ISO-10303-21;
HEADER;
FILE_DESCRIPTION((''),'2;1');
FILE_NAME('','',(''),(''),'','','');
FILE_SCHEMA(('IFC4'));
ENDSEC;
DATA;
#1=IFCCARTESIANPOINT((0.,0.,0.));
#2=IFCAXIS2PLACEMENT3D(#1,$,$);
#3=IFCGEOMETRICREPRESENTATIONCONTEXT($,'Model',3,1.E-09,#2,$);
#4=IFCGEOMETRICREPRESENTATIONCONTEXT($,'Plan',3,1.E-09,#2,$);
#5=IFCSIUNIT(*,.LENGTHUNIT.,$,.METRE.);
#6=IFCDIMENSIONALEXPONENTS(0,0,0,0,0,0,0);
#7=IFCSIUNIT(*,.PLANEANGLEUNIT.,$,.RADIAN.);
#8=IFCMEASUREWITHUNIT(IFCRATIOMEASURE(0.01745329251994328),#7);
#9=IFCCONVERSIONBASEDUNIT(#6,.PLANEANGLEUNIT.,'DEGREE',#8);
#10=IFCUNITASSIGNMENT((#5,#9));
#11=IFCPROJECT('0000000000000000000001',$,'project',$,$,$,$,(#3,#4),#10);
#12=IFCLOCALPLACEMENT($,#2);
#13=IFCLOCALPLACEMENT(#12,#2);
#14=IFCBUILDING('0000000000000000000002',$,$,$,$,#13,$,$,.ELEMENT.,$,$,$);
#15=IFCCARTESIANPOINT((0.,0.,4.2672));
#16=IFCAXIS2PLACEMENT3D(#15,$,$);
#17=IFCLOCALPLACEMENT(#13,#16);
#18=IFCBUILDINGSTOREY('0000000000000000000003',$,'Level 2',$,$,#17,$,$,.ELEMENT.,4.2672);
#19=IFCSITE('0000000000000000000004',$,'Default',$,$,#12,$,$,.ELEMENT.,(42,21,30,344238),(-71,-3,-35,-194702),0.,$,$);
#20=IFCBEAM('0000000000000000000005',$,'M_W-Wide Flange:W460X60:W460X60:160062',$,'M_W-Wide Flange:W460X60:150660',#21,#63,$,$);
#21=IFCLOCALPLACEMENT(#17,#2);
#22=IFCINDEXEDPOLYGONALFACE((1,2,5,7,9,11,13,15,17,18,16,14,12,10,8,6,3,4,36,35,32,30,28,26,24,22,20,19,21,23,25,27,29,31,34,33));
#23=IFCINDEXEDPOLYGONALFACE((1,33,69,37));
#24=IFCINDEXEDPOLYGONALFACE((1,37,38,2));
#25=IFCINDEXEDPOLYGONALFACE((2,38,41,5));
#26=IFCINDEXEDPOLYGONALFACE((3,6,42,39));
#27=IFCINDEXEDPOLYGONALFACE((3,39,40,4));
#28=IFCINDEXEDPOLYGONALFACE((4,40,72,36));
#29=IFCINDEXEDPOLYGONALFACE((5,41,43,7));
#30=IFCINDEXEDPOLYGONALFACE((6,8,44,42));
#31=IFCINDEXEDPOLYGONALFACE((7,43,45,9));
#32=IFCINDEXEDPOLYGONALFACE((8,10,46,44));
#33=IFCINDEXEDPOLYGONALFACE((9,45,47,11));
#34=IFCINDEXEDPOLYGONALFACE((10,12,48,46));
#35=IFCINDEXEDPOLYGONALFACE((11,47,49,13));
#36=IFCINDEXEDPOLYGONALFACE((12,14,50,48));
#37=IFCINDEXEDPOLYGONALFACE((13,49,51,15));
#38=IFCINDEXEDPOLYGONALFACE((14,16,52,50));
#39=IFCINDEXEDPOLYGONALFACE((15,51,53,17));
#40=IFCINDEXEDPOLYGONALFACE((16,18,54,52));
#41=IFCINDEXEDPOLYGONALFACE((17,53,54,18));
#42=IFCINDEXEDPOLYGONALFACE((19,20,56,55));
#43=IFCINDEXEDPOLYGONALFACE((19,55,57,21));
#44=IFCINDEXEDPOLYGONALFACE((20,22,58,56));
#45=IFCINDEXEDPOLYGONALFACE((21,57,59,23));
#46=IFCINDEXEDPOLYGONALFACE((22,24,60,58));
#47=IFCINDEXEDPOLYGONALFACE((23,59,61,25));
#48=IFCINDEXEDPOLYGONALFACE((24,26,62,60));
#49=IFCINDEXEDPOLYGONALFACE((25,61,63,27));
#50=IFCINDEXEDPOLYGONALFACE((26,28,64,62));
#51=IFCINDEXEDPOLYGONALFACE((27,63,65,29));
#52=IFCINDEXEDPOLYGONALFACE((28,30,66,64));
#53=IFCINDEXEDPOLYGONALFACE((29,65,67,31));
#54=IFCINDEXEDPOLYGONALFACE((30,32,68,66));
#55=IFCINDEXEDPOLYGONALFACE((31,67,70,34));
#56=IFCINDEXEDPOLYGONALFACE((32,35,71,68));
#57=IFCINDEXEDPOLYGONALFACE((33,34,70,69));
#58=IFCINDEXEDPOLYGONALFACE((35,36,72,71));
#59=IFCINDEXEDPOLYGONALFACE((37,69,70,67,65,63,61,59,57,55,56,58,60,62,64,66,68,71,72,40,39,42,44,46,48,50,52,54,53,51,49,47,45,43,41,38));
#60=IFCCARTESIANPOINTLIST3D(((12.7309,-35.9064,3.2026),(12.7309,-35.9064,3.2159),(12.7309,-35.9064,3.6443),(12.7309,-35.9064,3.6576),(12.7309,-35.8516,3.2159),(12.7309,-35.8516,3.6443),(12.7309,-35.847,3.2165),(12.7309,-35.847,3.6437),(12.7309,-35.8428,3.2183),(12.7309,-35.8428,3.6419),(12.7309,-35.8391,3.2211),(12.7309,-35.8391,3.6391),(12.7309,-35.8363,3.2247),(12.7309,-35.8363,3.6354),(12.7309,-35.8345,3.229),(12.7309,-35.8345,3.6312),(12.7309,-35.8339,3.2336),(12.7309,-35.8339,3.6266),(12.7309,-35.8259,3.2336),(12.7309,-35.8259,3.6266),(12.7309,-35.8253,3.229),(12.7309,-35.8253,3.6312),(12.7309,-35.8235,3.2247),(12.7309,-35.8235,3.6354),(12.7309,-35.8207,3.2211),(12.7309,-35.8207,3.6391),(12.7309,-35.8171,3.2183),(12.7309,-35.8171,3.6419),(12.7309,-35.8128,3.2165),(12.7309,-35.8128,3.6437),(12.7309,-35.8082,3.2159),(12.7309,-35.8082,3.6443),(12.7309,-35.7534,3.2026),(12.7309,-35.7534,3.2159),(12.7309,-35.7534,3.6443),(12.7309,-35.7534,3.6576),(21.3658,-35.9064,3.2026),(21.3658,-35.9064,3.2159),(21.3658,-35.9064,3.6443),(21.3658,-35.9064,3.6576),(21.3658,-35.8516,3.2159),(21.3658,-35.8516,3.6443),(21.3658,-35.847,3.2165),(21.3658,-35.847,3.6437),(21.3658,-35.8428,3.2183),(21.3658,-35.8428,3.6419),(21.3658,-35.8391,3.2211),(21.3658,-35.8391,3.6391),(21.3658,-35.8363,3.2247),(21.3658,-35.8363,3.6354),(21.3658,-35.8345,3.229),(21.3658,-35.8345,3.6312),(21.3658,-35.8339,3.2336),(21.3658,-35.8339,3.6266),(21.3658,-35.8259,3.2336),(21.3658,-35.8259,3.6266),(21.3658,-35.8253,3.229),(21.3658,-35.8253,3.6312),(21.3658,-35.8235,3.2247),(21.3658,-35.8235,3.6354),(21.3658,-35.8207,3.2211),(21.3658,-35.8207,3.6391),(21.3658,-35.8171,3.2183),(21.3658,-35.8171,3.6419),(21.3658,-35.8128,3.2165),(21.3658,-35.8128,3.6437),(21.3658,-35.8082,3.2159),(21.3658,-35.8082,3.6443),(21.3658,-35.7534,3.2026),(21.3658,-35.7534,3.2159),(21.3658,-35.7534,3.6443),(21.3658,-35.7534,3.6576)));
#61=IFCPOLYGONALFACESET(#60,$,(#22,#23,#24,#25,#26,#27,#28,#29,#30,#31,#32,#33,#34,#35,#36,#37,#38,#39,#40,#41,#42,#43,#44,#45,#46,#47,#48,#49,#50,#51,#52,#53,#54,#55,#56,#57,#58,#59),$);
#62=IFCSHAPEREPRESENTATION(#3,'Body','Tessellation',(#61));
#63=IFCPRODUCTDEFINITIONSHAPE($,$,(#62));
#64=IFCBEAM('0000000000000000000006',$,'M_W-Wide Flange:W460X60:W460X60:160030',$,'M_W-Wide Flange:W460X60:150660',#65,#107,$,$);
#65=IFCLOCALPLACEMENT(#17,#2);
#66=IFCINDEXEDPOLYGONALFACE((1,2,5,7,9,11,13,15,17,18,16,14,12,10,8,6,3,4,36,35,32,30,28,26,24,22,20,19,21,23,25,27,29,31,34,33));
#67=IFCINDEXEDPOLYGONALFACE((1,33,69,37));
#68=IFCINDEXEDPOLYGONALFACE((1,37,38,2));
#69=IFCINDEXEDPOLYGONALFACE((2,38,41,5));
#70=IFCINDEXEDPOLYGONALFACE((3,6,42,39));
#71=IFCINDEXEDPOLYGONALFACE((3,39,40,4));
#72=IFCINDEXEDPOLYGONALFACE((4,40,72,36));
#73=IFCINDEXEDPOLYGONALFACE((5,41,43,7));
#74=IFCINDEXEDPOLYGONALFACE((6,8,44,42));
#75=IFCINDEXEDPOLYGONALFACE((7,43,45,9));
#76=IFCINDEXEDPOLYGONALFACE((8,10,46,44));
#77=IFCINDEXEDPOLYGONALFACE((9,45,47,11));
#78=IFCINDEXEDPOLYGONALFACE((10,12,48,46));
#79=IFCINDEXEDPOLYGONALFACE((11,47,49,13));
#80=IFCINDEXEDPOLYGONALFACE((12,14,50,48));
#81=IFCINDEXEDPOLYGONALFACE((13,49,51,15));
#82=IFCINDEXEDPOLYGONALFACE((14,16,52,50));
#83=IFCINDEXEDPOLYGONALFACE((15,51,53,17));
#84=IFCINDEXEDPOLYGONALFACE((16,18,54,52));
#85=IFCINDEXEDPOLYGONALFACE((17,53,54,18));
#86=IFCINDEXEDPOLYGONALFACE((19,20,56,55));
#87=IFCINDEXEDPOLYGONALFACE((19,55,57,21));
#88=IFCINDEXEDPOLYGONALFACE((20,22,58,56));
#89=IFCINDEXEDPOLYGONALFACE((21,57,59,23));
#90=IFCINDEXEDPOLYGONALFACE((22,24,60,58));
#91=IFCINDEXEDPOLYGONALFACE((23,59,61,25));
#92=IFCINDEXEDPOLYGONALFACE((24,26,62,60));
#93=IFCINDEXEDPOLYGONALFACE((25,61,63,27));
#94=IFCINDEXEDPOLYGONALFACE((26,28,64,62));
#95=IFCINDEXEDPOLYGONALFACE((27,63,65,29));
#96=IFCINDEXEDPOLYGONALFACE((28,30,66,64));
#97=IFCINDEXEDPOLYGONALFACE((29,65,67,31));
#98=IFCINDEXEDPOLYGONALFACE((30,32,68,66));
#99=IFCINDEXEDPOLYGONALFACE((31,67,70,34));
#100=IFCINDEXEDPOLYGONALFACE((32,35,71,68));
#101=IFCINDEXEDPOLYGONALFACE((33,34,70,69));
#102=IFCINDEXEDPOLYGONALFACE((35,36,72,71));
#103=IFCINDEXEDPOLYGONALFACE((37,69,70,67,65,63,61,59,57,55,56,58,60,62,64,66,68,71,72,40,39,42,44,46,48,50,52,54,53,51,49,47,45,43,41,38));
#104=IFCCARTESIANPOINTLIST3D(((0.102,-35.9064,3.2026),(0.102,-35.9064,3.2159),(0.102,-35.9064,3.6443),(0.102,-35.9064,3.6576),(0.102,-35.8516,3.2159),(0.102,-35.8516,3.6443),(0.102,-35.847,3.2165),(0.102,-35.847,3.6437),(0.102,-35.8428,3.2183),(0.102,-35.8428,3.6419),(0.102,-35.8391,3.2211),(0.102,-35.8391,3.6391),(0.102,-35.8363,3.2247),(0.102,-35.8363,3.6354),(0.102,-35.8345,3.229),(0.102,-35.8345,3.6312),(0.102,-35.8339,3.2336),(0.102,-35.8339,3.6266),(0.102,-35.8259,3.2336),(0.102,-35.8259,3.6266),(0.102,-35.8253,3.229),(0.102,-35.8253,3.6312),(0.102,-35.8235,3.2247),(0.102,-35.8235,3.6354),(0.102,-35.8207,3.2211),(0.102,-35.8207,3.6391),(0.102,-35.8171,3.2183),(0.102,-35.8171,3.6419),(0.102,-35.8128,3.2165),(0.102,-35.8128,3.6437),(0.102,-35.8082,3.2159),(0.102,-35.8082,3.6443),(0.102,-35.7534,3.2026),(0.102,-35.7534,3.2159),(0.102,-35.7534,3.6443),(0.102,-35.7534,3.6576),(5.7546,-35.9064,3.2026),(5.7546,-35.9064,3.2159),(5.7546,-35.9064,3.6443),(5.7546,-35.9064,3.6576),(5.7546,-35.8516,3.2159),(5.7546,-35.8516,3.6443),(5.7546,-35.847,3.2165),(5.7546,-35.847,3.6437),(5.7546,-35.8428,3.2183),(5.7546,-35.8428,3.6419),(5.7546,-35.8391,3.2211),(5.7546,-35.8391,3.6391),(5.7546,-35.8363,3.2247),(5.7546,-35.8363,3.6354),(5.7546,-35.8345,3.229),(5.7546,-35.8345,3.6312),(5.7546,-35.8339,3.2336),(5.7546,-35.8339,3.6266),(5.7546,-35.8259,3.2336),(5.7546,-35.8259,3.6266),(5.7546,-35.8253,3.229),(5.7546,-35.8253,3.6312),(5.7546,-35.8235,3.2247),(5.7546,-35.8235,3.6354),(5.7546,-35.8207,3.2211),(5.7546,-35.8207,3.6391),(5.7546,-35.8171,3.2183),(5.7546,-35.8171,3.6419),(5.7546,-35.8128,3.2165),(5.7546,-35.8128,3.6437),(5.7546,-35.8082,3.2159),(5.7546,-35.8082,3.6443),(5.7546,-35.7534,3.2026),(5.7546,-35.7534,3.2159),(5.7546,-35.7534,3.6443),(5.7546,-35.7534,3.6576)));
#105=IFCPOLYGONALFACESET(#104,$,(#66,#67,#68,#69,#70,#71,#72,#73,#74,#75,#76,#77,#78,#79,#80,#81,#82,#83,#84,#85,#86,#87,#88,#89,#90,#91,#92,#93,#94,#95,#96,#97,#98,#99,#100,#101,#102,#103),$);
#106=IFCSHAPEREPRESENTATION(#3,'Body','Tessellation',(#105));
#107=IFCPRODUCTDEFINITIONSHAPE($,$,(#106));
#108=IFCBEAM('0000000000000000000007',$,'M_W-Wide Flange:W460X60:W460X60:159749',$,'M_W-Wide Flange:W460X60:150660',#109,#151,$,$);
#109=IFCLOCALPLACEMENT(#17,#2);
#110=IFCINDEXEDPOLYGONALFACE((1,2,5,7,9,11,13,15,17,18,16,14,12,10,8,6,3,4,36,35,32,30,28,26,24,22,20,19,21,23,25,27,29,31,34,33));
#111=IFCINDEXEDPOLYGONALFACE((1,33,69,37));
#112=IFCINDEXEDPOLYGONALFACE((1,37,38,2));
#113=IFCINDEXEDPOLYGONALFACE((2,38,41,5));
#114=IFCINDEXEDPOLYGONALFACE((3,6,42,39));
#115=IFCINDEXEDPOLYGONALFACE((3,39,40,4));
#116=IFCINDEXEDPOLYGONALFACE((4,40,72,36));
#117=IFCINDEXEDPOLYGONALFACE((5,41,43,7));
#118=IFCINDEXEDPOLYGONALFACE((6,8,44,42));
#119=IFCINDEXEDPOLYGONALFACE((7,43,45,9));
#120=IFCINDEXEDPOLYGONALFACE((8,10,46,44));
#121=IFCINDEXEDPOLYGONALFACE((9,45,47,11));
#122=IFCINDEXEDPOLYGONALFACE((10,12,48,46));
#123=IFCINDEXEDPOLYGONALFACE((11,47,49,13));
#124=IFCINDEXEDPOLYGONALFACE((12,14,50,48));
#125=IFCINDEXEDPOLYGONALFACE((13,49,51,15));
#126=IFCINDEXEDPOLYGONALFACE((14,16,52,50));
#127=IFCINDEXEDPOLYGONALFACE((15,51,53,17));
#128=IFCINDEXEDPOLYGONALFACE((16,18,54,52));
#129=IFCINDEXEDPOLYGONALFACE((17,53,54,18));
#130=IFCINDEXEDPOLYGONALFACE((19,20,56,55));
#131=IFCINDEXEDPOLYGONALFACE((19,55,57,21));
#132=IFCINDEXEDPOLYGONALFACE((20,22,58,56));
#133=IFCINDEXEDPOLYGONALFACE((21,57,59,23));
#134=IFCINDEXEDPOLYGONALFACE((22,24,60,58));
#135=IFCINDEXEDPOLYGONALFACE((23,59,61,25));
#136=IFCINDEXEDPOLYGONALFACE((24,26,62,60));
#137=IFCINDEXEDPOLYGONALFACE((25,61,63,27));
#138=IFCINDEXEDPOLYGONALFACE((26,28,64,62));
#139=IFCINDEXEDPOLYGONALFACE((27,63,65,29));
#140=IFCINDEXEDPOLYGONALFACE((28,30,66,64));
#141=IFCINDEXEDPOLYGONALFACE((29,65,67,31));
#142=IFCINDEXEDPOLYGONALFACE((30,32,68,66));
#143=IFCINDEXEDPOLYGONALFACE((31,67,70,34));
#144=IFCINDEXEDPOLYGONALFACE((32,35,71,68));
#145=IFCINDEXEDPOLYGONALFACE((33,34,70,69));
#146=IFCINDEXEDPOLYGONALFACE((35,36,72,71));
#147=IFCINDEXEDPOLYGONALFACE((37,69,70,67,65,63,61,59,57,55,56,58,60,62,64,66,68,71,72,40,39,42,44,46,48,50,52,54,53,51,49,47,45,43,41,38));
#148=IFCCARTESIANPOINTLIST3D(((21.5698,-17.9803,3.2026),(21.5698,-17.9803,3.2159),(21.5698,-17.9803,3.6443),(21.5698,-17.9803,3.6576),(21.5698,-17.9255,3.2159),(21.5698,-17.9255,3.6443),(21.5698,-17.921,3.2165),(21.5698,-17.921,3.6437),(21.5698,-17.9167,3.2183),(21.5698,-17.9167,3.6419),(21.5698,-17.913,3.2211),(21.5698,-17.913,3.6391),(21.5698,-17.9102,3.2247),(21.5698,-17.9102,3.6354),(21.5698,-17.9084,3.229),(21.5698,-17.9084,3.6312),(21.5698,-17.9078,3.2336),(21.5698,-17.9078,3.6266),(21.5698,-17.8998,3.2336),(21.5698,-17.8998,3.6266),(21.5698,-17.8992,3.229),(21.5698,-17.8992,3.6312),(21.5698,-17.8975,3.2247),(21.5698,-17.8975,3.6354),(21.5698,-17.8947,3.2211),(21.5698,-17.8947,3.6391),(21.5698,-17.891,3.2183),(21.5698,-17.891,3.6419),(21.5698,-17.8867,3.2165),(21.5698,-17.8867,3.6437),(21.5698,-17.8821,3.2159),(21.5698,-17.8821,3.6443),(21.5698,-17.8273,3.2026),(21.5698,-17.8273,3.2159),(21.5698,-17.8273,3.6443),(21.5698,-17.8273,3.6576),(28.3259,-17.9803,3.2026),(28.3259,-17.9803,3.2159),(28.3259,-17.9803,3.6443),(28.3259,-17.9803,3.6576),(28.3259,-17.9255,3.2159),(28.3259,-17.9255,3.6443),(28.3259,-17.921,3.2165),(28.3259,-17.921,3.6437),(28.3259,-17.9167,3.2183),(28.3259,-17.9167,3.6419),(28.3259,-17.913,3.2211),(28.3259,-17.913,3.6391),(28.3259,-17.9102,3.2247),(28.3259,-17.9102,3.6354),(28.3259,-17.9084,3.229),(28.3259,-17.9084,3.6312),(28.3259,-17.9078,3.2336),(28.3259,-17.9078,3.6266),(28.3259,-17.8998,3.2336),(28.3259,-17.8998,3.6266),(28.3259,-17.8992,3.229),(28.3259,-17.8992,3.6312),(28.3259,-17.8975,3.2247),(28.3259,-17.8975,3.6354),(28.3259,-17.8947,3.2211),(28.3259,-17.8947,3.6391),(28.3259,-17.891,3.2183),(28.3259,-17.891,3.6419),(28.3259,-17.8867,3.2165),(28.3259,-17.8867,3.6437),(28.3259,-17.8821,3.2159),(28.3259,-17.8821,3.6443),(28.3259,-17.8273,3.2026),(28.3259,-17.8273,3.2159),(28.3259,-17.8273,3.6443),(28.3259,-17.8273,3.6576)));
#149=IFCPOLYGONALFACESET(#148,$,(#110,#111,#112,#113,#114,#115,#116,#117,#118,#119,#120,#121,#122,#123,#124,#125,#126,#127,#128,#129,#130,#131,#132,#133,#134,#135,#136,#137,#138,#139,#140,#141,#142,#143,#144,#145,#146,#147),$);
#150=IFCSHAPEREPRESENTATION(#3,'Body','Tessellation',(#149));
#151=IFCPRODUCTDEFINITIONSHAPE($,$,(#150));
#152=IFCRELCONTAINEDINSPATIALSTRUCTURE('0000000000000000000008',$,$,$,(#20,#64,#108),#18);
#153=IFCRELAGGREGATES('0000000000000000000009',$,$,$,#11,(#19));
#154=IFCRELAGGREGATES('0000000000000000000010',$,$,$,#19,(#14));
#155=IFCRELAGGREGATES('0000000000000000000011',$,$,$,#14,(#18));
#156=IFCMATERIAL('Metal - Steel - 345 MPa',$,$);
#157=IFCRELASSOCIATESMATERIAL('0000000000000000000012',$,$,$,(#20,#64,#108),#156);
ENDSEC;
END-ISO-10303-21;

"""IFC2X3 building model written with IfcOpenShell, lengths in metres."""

from ifc_helpers import new_model, entity, si_unit, converted_unit, frame, frame_2d, origin, place, context, project, spatial, polyline, circle_curve, parameter, trimmed, segment, composite_curve, outline, extrude, material, element, save


model = new_model("IFC2X3")

# Units and contexts
model_context = context("Model", 3, precision=1e-09, world=origin())
plan_context = context("Plan", 3, precision=1e-09, world=origin())
ifc_project = project(units=[si_unit("LENGTHUNIT", "METRE"), converted_unit("PLANEANGLEUNIT", "DEGREE", entity("IfcRatioMeasure", 0.01745329251994328), si_unit("PLANEANGLEUNIT", "RADIAN"), dimensions=[0, 0, 0, 0, 0, 0, 0])], contexts=[model_context, plan_context])

# Site, building, storey
site_placement = place(None, origin())
site = spatial("IfcSite", under=ifc_project, at=site_placement, Name="Default", CompositionType="ELEMENT", RefLatitude=(42, 21, 30, 344238), RefLongitude=(-71, -3, -35, -194702), RefElevation=0.0)
building_placement = place(site_placement, origin())
building = spatial("IfcBuilding", under=site, at=building_placement, CompositionType="ELEMENT")
storey_placement = place(building_placement, frame((0.0, 0.0, 4.2672)))
storey = spatial("IfcBuildingStorey", under=building, at=storey_placement, Name="Level 2", CompositionType="ELEMENT", Elevation=4.2672)

# Shared definitions
ifc_material_1 = material(Name="Metal - Steel - 345 MPa")

# Beams
beam_1_placement = place(storey_placement, frame((12.6289, -35.8299, 3.6576), z_axis=(0.0, 0.0, 1.0), x_axis=(0.0, -1.0, 0.0)))
element("IfcBeam", 1, at=beam_1_placement, inside=storey, material=ifc_material_1, Name="M_W-Wide Flange:W460X60:W460X60:160062", ObjectType="M_W-Wide Flange:W460X60:150660", context=model_context, shape_type="SweptSolid", body=[
    extrude(outline(composite_curve([segment(polyline([(-0.0765, -0.2142), (-0.0765, -0.2275)]), True, "CONTINUOUS"), segment(polyline([(-0.0765, -0.2275), (0.0765, -0.2275)]), True, "CONTINUOUS"), segment(polyline([(0.0765, -0.2275), (0.0765, -0.2142)]), True, "CONTINUOUS"), segment(polyline([(0.0765, -0.2142), (0.0217, -0.2142)]), True, "CONTINUOUS"), segment(trimmed(circle_curve(frame_2d((0.0217, -0.1965), x_axis=(0.0, -1.0)), 0.0177), [parameter(270.0)], [parameter(360.0)], True, "PARAMETER"), False, "CONTINUOUS"), segment(polyline([(0.004, -0.1965), (0.004, 0.1965)]), True, "CONTINUOUS"), segment(trimmed(circle_curve(frame_2d((0.0217, 0.1965), x_axis=(-1.0, 0.0)), 0.0177), [parameter(270.0)], [parameter(360.0)], True, "PARAMETER"), False, "CONTINUOUS"), segment(polyline([(0.0217, 0.2142), (0.0765, 0.2142)]), True, "CONTINUOUS"), segment(polyline([(0.0765, 0.2142), (0.0765, 0.2275)]), True, "CONTINUOUS"), segment(polyline([(0.0765, 0.2275), (-0.0765, 0.2275)]), True, "CONTINUOUS"), segment(polyline([(-0.0765, 0.2275), (-0.0765, 0.2142)]), True, "CONTINUOUS"), segment(polyline([(-0.0765, 0.2142), (-0.0217, 0.2142)]), True, "CONTINUOUS"), segment(trimmed(circle_curve(frame_2d((-0.0217, 0.1965), x_axis=(0.0, 1.0)), 0.0177), [parameter(270.0)], [parameter(360.0)], True, "PARAMETER"), False, "CONTINUOUS"), segment(polyline([(-0.004, 0.1965), (-0.004, -0.1965)]), True, "CONTINUOUS"), segment(trimmed(circle_curve(frame_2d((-0.0217, -0.1965), x_axis=(1.0, 0.0)), 0.0177), [parameter(270.0)], [parameter(0.0)], True, "PARAMETER"), False, "CONTINUOUS"), segment(polyline([(-0.0217, -0.2142), (-0.0765, -0.2142)]), True, "CONTINUOUS")], self_intersect=False)), frame((0.0, 0.102, -0.2275), z_axis=(0.0, -1.0, 0.0), x_axis=(1.0, 0.0, 0.0)), (0.0, 0.0, -1.0), 8.6349),
])
beam_2_placement = place(storey_placement, frame((0.0, -35.8299, 3.6576), z_axis=(0.0, 0.0, 1.0), x_axis=(0.0, -1.0, 0.0)))
element("IfcBeam", 2, at=beam_2_placement, inside=storey, material=ifc_material_1, Name="M_W-Wide Flange:W460X60:W460X60:160030", ObjectType="M_W-Wide Flange:W460X60:150660", context=model_context, shape_type="SweptSolid", body=[
    extrude(outline(composite_curve([segment(polyline([(-0.0765, -0.2142), (-0.0765, -0.2275)]), True, "CONTINUOUS"), segment(polyline([(-0.0765, -0.2275), (0.0765, -0.2275)]), True, "CONTINUOUS"), segment(polyline([(0.0765, -0.2275), (0.0765, -0.2142)]), True, "CONTINUOUS"), segment(polyline([(0.0765, -0.2142), (0.0217, -0.2142)]), True, "CONTINUOUS"), segment(trimmed(circle_curve(frame_2d((0.0217, -0.1965), x_axis=(1.0, 0.0)), 0.0177), [parameter(180.0)], [parameter(270.0)], True, "PARAMETER"), False, "CONTINUOUS"), segment(polyline([(0.004, -0.1965), (0.004, 0.1965)]), True, "CONTINUOUS"), segment(trimmed(circle_curve(frame_2d((0.0217, 0.1965), x_axis=(1.0, 0.0)), 0.0177), [parameter(90.0)], [parameter(180.0)], True, "PARAMETER"), False, "CONTINUOUS"), segment(polyline([(0.0217, 0.2142), (0.0765, 0.2142)]), True, "CONTINUOUS"), segment(polyline([(0.0765, 0.2142), (0.0765, 0.2275)]), True, "CONTINUOUS"), segment(polyline([(0.0765, 0.2275), (-0.0765, 0.2275)]), True, "CONTINUOUS"), segment(polyline([(-0.0765, 0.2275), (-0.0765, 0.2142)]), True, "CONTINUOUS"), segment(polyline([(-0.0765, 0.2142), (-0.0217, 0.2142)]), True, "CONTINUOUS"), segment(trimmed(circle_curve(frame_2d((-0.0217, 0.1965), x_axis=(1.0, 0.0)), 0.0177), [parameter(360.0)], [parameter(90.0)], True, "PARAMETER"), False, "CONTINUOUS"), segment(polyline([(-0.004, 0.1965), (-0.004, -0.1965)]), True, "CONTINUOUS"), segment(trimmed(circle_curve(frame_2d((-0.0217, -0.1965), x_axis=(1.0, 0.0)), 0.0177), [parameter(270.0)], [parameter(0.0)], True, "PARAMETER"), False, "CONTINUOUS"), segment(polyline([(-0.0217, -0.2142), (-0.0765, -0.2142)]), True, "CONTINUOUS")], self_intersect=False)), frame((0.0, 0.102, -0.2275), z_axis=(0.0, -1.0, 0.0), x_axis=(1.0, 0.0, 0.0)), (0.0, 0.0, -1.0), 5.6526),
])
beam_3_placement = place(storey_placement, frame((21.4678, -17.9038, 3.6576), z_axis=(0.0, 0.0, 1.0), x_axis=(0.0, -1.0, 0.0)))
element("IfcBeam", 3, at=beam_3_placement, inside=storey, material=ifc_material_1, Name="M_W-Wide Flange:W460X60:W460X60:159749", ObjectType="M_W-Wide Flange:W460X60:150660", context=model_context, shape_type="SweptSolid", body=[
    extrude(outline(composite_curve([segment(polyline([(-0.0765, -0.2142), (-0.0765, -0.2275)]), True, "CONTINUOUS"), segment(polyline([(-0.0765, -0.2275), (0.0765, -0.2275)]), True, "CONTINUOUS"), segment(polyline([(0.0765, -0.2275), (0.0765, -0.2142)]), True, "CONTINUOUS"), segment(polyline([(0.0765, -0.2142), (0.0217, -0.2142)]), True, "CONTINUOUS"), segment(trimmed(circle_curve(frame_2d((0.0217, -0.1965), x_axis=(0.0, -1.0)), 0.0177), [parameter(270.0)], [parameter(360.0)], True, "PARAMETER"), False, "CONTINUOUS"), segment(polyline([(0.004, -0.1965), (0.004, 0.1965)]), True, "CONTINUOUS"), segment(trimmed(circle_curve(frame_2d((0.0217, 0.1965), x_axis=(-1.0, 0.0)), 0.0177), [parameter(270.0)], [parameter(360.0)], True, "PARAMETER"), False, "CONTINUOUS"), segment(polyline([(0.0217, 0.2142), (0.0765, 0.2142)]), True, "CONTINUOUS"), segment(polyline([(0.0765, 0.2142), (0.0765, 0.2275)]), True, "CONTINUOUS"), segment(polyline([(0.0765, 0.2275), (-0.0765, 0.2275)]), True, "CONTINUOUS"), segment(polyline([(-0.0765, 0.2275), (-0.0765, 0.2142)]), True, "CONTINUOUS"), segment(polyline([(-0.0765, 0.2142), (-0.0217, 0.2142)]), True, "CONTINUOUS"), segment(trimmed(circle_curve(frame_2d((-0.0217, 0.1965), x_axis=(0.0, 1.0)), 0.0177), [parameter(270.0)], [parameter(360.0)], True, "PARAMETER"), False, "CONTINUOUS"), segment(polyline([(-0.004, 0.1965), (-0.004, -0.1965)]), True, "CONTINUOUS"), segment(trimmed(circle_curve(frame_2d((-0.0217, -0.1965), x_axis=(1.0, 0.0)), 0.0177), [parameter(270.0)], [parameter(0.0)], True, "PARAMETER"), False, "CONTINUOUS"), segment(polyline([(-0.0217, -0.2142), (-0.0765, -0.2142)]), True, "CONTINUOUS")], self_intersect=False)), frame((0.0, 0.102, -0.2275), z_axis=(0.0, -1.0, 0.0), x_axis=(1.0, 0.0, 0.0)), (0.0, 0.0, -1.0), 6.7561),
])

save(model, "model.ifc")
